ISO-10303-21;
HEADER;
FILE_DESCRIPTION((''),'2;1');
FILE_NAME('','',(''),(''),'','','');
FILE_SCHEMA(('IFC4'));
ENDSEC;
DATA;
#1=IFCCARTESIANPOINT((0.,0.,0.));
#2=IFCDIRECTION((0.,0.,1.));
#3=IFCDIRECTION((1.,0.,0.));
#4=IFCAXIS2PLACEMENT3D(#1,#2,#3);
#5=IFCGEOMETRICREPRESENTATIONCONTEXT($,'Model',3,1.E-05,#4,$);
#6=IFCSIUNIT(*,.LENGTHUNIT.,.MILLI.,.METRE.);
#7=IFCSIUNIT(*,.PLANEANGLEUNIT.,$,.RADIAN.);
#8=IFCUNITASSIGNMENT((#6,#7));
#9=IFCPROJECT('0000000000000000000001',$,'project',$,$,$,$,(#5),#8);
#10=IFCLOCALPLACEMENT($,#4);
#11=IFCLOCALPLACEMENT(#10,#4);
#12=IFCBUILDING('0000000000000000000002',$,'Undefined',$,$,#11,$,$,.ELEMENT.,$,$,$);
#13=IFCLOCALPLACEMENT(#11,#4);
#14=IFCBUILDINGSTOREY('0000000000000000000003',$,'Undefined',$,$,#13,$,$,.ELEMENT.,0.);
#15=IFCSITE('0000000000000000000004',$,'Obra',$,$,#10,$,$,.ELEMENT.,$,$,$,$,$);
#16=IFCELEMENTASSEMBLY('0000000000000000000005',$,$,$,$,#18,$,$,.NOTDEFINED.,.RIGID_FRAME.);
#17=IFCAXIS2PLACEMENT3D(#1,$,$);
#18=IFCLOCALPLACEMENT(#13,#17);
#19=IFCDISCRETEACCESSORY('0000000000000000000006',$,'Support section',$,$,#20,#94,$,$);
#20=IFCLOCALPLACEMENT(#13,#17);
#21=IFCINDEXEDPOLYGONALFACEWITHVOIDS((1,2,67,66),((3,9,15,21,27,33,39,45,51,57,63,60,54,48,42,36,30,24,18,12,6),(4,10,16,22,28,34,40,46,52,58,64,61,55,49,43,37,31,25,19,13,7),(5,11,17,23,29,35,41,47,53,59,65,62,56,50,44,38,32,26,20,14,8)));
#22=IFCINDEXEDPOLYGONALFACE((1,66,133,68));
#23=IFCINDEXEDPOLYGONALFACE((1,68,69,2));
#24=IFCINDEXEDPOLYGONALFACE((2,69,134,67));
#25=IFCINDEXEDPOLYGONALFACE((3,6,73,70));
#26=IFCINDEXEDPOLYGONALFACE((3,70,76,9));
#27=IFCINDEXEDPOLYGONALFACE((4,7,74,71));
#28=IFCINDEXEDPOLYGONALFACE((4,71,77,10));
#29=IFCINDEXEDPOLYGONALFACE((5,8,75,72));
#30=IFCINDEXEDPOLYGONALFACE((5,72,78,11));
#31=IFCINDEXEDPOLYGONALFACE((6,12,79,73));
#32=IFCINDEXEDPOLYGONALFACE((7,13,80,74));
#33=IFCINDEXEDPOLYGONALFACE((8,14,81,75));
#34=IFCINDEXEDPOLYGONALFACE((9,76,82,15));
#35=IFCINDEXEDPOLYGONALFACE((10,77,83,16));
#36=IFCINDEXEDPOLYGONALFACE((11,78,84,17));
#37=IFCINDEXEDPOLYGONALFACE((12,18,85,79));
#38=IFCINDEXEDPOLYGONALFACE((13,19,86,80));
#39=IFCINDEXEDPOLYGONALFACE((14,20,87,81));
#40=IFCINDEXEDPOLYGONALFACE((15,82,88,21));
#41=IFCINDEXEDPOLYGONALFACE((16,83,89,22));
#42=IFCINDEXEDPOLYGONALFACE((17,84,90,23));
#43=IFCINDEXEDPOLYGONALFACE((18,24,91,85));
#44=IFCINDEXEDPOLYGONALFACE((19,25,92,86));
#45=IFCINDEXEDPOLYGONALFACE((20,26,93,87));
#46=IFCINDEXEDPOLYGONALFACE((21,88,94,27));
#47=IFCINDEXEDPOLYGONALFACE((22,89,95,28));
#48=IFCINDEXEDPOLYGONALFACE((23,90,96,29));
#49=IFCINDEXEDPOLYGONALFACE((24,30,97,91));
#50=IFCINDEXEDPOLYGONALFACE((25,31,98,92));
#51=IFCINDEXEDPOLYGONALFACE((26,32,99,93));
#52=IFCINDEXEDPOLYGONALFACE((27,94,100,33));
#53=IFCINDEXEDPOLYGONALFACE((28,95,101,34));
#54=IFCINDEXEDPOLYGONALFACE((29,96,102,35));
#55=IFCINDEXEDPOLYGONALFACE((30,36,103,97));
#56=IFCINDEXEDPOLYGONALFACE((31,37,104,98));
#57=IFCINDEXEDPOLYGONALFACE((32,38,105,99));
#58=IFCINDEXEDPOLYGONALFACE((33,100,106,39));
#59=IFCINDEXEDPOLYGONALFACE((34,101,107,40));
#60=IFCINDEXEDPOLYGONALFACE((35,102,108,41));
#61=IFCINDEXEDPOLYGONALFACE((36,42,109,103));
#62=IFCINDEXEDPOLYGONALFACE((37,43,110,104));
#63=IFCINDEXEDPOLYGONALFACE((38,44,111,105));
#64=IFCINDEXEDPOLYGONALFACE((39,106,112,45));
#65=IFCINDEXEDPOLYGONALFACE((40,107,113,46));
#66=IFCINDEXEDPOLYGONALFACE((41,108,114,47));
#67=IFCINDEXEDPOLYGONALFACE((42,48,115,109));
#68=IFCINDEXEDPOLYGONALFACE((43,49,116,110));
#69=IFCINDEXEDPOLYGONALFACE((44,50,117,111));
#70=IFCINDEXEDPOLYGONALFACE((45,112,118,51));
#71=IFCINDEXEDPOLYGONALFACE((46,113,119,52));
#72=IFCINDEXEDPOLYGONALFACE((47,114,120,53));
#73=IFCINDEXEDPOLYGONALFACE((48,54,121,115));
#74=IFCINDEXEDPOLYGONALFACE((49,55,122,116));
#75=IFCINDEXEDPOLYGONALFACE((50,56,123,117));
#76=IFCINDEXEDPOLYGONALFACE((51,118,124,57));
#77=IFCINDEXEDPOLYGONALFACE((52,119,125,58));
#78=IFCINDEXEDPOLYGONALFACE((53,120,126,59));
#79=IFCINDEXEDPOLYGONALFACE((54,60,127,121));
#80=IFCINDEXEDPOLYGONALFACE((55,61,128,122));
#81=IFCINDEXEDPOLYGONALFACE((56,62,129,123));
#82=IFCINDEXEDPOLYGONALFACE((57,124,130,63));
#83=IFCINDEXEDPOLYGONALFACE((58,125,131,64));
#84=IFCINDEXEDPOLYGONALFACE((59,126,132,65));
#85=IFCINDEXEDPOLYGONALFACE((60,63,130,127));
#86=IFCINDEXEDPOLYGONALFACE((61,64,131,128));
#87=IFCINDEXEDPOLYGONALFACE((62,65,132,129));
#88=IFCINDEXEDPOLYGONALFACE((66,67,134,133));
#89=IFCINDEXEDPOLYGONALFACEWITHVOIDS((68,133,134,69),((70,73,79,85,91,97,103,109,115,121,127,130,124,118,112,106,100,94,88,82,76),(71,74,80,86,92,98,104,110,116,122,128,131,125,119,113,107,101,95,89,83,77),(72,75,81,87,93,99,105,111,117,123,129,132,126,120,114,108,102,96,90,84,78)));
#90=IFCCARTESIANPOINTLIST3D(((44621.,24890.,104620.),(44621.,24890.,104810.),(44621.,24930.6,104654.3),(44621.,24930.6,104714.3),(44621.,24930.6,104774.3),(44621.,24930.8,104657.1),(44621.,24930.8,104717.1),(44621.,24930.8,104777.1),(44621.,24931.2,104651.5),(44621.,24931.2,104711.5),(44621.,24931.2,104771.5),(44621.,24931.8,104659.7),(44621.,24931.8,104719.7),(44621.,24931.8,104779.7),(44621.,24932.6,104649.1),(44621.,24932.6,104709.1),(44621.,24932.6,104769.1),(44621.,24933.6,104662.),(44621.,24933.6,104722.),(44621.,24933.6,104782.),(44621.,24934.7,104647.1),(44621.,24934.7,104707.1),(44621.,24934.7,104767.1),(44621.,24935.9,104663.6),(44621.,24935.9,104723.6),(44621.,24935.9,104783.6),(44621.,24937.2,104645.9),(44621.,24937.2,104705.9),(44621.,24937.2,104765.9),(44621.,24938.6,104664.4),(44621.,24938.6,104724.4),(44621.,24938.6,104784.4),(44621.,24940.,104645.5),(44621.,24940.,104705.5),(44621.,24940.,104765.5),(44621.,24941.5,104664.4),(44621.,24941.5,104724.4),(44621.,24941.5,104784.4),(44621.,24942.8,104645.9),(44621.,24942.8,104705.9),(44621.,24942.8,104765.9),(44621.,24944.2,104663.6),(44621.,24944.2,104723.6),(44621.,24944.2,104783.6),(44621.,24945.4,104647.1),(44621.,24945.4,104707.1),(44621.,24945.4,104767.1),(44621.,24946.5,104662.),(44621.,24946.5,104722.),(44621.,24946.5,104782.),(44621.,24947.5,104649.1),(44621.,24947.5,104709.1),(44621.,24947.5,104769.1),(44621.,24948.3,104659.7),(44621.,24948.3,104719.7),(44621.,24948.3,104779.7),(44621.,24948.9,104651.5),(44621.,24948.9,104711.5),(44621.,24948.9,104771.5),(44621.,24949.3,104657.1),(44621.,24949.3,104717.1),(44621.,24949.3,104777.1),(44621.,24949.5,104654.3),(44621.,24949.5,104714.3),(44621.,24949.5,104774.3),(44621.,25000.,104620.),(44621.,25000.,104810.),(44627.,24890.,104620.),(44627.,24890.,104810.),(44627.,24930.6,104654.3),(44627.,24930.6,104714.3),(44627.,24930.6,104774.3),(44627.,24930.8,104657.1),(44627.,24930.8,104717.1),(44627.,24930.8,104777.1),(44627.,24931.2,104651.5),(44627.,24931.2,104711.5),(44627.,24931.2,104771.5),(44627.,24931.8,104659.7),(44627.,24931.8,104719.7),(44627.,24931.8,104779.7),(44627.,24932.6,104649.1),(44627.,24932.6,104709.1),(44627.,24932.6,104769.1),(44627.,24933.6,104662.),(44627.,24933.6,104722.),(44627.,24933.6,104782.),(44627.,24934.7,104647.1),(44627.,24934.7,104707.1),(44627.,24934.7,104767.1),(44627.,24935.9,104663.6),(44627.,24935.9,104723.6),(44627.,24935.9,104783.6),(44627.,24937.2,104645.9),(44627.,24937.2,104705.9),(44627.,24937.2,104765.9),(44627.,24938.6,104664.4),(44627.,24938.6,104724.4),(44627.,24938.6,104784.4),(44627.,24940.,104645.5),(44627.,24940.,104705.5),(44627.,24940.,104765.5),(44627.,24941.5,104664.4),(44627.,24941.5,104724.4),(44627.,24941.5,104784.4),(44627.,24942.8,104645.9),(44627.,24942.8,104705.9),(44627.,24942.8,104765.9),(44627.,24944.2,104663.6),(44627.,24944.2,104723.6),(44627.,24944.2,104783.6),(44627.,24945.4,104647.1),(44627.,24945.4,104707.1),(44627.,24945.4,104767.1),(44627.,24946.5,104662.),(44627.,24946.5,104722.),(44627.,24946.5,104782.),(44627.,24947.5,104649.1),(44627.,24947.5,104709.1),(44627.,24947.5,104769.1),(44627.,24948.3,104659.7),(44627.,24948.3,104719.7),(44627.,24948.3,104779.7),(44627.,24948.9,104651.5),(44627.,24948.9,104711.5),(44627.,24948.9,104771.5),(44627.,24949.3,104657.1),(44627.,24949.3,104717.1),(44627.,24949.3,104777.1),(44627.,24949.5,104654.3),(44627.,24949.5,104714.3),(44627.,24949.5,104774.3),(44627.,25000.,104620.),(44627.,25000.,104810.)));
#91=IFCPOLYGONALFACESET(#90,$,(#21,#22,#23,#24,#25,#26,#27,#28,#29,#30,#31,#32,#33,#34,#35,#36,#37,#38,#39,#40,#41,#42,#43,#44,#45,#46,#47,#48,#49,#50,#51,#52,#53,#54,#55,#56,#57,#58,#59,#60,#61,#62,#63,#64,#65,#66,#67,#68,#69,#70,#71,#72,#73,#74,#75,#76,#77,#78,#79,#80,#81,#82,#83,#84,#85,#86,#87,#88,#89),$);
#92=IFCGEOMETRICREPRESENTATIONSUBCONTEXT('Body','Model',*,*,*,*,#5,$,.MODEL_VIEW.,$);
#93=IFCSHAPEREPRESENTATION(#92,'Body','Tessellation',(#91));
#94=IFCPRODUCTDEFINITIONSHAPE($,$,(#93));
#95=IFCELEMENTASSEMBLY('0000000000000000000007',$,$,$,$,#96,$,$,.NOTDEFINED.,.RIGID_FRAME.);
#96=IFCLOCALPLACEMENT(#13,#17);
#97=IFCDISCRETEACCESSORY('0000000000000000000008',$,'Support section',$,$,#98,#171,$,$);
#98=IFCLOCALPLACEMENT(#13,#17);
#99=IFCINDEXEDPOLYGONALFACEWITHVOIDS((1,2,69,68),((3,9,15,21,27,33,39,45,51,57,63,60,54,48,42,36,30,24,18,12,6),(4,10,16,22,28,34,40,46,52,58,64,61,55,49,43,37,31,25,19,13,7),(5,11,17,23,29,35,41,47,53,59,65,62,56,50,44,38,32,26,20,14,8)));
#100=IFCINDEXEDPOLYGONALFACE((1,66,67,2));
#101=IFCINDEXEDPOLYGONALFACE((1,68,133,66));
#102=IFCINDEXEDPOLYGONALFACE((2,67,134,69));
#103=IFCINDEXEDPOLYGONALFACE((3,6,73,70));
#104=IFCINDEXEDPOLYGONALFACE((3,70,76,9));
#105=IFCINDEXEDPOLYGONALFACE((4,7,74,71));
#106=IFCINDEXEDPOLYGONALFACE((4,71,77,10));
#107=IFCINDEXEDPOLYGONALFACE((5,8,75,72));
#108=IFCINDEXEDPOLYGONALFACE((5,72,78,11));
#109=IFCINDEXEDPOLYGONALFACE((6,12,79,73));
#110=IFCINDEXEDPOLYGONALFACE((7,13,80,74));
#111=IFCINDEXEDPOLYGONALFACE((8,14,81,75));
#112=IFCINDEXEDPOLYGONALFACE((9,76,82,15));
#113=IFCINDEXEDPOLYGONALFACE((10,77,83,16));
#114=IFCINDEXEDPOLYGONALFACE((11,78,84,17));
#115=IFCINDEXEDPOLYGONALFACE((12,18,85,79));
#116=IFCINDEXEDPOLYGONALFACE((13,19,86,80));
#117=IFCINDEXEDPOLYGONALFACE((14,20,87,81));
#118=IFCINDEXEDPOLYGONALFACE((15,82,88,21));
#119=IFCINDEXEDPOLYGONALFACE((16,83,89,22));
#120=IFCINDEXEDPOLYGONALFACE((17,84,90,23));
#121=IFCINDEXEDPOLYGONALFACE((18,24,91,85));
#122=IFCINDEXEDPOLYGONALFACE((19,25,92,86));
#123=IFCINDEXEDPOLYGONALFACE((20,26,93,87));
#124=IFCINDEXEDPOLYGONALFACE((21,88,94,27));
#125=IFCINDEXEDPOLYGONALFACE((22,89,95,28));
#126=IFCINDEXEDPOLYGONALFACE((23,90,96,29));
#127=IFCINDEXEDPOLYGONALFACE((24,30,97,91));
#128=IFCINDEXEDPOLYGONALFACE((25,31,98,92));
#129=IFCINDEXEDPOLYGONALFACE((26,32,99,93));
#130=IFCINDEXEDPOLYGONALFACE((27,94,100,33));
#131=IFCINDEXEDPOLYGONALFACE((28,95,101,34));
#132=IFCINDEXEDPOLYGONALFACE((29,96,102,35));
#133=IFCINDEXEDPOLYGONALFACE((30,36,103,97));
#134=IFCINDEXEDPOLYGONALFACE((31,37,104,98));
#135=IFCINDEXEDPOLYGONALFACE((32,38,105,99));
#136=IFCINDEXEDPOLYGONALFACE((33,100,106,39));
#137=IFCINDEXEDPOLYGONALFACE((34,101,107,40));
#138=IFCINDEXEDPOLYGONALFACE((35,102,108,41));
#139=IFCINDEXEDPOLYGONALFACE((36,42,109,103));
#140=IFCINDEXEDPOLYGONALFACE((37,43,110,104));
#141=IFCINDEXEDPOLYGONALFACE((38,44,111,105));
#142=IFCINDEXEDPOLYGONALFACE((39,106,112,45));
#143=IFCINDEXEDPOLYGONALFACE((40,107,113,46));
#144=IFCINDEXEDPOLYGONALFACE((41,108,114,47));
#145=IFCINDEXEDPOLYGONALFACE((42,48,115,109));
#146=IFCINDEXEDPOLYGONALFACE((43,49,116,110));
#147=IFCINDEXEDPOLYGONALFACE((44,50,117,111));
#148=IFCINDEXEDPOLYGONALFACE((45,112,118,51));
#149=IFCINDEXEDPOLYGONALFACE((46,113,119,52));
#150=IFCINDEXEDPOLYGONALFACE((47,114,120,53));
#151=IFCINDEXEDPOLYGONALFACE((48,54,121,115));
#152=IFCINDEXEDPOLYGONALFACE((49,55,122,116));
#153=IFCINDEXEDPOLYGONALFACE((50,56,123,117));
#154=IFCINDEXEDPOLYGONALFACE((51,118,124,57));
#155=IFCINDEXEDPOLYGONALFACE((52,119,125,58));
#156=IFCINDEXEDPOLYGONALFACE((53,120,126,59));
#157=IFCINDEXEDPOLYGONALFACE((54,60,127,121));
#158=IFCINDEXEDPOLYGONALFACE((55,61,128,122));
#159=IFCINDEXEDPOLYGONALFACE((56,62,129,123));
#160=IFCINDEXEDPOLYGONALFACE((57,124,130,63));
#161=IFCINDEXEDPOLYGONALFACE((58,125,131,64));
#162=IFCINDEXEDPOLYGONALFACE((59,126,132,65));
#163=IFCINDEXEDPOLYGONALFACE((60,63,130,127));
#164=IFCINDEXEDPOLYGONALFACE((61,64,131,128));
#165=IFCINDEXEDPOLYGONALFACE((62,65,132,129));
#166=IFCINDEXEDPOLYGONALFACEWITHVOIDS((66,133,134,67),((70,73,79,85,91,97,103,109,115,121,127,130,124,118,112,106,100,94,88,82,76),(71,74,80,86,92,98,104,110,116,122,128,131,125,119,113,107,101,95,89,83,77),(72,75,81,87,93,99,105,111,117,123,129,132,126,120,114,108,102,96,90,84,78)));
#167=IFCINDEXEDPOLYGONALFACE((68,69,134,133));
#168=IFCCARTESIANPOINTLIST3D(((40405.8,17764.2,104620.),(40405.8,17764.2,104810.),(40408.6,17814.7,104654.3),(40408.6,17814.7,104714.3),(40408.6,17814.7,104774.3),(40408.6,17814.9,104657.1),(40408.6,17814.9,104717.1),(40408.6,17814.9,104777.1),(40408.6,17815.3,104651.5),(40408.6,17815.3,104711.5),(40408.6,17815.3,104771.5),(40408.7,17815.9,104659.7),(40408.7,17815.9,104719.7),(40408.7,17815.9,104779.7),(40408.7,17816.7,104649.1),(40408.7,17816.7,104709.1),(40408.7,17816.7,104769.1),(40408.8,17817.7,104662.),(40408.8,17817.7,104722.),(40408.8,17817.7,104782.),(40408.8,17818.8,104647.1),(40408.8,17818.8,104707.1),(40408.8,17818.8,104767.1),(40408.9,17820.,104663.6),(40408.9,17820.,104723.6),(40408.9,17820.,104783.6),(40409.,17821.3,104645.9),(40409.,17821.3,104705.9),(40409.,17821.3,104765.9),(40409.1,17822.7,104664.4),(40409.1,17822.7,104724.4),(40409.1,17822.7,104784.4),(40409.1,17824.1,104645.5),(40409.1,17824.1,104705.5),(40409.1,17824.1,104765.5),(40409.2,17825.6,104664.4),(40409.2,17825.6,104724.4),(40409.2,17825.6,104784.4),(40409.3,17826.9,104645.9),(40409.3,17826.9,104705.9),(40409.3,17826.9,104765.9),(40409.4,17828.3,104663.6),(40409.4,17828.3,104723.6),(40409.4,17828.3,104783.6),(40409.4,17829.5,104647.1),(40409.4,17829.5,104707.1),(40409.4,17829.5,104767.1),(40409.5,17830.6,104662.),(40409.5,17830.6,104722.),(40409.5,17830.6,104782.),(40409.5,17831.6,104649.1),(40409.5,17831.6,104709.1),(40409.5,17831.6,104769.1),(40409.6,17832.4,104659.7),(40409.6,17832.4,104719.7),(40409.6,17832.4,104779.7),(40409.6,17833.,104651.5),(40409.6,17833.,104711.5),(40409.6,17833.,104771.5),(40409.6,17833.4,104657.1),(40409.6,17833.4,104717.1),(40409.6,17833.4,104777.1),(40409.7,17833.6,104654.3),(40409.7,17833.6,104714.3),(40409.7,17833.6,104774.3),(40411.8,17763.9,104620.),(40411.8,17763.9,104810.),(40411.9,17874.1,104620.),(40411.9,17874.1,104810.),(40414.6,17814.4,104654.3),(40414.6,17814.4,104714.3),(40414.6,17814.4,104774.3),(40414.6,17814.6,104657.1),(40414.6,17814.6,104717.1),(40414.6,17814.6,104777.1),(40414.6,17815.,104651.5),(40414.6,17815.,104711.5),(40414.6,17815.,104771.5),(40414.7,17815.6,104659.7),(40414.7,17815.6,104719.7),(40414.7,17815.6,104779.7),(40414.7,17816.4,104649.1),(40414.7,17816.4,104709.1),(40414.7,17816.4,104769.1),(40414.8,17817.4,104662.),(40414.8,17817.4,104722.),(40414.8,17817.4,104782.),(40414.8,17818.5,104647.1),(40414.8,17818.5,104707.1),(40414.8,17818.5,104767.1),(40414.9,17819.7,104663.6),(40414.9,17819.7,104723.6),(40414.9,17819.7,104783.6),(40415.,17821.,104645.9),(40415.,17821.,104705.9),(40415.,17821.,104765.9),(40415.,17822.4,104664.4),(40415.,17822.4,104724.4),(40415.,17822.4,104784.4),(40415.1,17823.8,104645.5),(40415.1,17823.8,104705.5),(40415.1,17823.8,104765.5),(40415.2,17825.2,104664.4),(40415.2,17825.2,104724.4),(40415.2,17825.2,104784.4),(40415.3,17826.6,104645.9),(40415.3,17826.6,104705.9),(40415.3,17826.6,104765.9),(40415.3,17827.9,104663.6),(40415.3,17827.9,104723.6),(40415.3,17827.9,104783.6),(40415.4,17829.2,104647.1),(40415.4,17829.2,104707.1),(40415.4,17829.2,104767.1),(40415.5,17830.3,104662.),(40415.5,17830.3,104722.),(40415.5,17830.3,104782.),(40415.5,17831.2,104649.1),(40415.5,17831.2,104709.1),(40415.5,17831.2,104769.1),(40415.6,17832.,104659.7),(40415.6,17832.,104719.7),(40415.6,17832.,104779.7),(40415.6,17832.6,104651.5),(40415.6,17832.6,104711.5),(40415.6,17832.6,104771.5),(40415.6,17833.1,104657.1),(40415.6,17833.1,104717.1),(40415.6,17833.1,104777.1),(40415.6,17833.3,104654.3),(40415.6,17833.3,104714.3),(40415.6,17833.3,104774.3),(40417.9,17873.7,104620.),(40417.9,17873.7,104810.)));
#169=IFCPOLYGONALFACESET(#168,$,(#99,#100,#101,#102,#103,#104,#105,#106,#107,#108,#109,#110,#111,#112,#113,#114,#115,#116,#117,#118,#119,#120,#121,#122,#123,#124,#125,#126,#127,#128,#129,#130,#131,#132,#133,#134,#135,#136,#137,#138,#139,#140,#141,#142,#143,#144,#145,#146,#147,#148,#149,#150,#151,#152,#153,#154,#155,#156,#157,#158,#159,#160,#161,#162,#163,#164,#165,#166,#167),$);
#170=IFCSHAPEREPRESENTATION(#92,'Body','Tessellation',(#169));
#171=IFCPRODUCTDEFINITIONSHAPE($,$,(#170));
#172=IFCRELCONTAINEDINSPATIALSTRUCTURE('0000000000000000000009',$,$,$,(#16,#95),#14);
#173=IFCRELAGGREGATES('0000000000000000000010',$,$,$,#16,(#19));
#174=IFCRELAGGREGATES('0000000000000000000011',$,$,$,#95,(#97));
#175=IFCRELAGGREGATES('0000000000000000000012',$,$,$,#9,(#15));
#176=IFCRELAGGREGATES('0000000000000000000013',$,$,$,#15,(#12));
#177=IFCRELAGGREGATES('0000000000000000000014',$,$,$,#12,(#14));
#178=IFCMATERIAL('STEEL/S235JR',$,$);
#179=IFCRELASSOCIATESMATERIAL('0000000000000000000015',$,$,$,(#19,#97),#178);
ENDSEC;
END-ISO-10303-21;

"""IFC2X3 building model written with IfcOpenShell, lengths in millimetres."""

from ifc_helpers import new_model, si_unit, frame, origin_with_axes, origin_2d_with_axis, place, context, subcontext, project, spatial, rectangle, circle, extrude, source, transform, mapped, material, element, aggregate, save


model = new_model("IFC2X3")

# Units and contexts
model_context = context("Model", 3, precision=1e-05, world=origin_with_axes())
body_context = subcontext(model_context, "Body", "Model", "MODEL_VIEW")
ifc_project = project(units=[si_unit("LENGTHUNIT", "METRE", prefix="MILLI"), si_unit("PLANEANGLEUNIT", "RADIAN")], contexts=[model_context])

# Site, building, storey
site_placement = place(None, origin_with_axes())
site = spatial("IfcSite", under=ifc_project, at=site_placement, Name="Obra", CompositionType="ELEMENT")
building_placement = place(site_placement, origin_with_axes())
building = spatial("IfcBuilding", under=site, at=building_placement, Name="Undefined", CompositionType="ELEMENT")
storey_placement = place(building_placement, origin_with_axes())
storey = spatial("IfcBuildingStorey", under=building, at=storey_placement, Name="Undefined", CompositionType="ELEMENT", Elevation=0.0)

# Shared definitions
ifc_material = material(Name="STEEL/S235JR")

# Element assemblies, discrete accessories, openings
shared_shape_1 = source(origin_with_axes(), body_context, "Body", "SweptSolid", [
    extrude(circle(Radius=9.5, at=origin_2d_with_axis()), frame((0.0, -9.2, 0.0), z_axis=(0.0, 1.0, 0.0), x_axis=(1.0, 0.0, 0.0)), (0.0, 0.0, 1.0), 6.2),
])
assembly_1_placement = place(storey_placement, origin_with_axes())
assembly_1 = element("IfcElementAssembly", 1, at=assembly_1_placement, inside=storey, AssemblyPlace="NOTDEFINED", PredefinedType="RIGID_FRAME")
discrete_accessory_1_placement = place(assembly_1_placement, frame((44624.0, 24945.0, 104620.0), z_axis=(0.0, 0.0, 1.0), x_axis=(-0.000002, 1.0, 0.0)))
discrete_accessory_1 = element("IfcDiscreteAccessory", 2, at=discrete_accessory_1_placement, material=ifc_material, Name="Support section", context=body_context, shape_type="SweptSolid", body=[
    extrude(rectangle(XDim=6.0, YDim=110.0, at=origin_2d_with_axis()), frame((0.0, 0.0, 190.0), z_axis=(0.0, 0.0, -1.0), x_axis=(0.0, 1.0, 0.0)), (0.0, 0.0, 1.0), 190.0),
])
opening_1_placement = place(assembly_1_placement, frame((44630.1, 24990.0, 104835.0), z_axis=(0.000002, -1.0, 0.0), x_axis=(0.0, 0.0, -1.0)))
element("IfcOpeningElement", 3, at=opening_1_placement, cuts=discrete_accessory_1, ObjectType="Opening", context=body_context, shape_type="MappedRepresentation", body=[
    mapped(shared_shape_1, transform((60.0, 0.0, 50.0))),
    mapped(shared_shape_1, transform((120.0, 0.0, 50.0))),
    mapped(shared_shape_1, transform((180.0, 0.0, 50.0))),
])
aggregate(assembly_1, [discrete_accessory_1])
assembly_2_placement = place(storey_placement, origin_with_axes())
assembly_2 = element("IfcElementAssembly", 4, at=assembly_2_placement, inside=storey, AssemblyPlace="NOTDEFINED", PredefinedType="RIGID_FRAME")
discrete_accessory_2_placement = place(assembly_2_placement, frame((40411.9, 17819.0, 104620.0), z_axis=(0.0, 0.0, 1.0), x_axis=(-0.055268, -0.998472, 0.0)))
discrete_accessory_2 = element("IfcDiscreteAccessory", 5, at=discrete_accessory_2_placement, material=ifc_material, Name="Support section", context=body_context, shape_type="SweptSolid", body=[
    extrude(rectangle(XDim=6.0, YDim=110.0, at=origin_2d_with_axis()), frame((0.0, 0.0, 190.0), z_axis=(0.0, 0.0, -1.0), x_axis=(0.0, 1.0, 0.0)), (0.0, 0.0, 1.0), 190.0),
])
opening_2_placement = place(assembly_2_placement, frame((40403.3, 17774.4, 104835.0), z_axis=(0.055268, 0.998472, 0.0), x_axis=(0.0, 0.0, -1.0)))
element("IfcOpeningElement", 6, at=opening_2_placement, cuts=discrete_accessory_2, ObjectType="Opening", context=body_context, shape_type="MappedRepresentation", body=[
    mapped(shared_shape_1, transform((60.0, 0.0, 50.0))),
    mapped(shared_shape_1, transform((120.0, 0.0, 50.0))),
    mapped(shared_shape_1, transform((180.0, 0.0, 50.0))),
])
aggregate(assembly_2, [discrete_accessory_2])

save(model, "model.ifc")
